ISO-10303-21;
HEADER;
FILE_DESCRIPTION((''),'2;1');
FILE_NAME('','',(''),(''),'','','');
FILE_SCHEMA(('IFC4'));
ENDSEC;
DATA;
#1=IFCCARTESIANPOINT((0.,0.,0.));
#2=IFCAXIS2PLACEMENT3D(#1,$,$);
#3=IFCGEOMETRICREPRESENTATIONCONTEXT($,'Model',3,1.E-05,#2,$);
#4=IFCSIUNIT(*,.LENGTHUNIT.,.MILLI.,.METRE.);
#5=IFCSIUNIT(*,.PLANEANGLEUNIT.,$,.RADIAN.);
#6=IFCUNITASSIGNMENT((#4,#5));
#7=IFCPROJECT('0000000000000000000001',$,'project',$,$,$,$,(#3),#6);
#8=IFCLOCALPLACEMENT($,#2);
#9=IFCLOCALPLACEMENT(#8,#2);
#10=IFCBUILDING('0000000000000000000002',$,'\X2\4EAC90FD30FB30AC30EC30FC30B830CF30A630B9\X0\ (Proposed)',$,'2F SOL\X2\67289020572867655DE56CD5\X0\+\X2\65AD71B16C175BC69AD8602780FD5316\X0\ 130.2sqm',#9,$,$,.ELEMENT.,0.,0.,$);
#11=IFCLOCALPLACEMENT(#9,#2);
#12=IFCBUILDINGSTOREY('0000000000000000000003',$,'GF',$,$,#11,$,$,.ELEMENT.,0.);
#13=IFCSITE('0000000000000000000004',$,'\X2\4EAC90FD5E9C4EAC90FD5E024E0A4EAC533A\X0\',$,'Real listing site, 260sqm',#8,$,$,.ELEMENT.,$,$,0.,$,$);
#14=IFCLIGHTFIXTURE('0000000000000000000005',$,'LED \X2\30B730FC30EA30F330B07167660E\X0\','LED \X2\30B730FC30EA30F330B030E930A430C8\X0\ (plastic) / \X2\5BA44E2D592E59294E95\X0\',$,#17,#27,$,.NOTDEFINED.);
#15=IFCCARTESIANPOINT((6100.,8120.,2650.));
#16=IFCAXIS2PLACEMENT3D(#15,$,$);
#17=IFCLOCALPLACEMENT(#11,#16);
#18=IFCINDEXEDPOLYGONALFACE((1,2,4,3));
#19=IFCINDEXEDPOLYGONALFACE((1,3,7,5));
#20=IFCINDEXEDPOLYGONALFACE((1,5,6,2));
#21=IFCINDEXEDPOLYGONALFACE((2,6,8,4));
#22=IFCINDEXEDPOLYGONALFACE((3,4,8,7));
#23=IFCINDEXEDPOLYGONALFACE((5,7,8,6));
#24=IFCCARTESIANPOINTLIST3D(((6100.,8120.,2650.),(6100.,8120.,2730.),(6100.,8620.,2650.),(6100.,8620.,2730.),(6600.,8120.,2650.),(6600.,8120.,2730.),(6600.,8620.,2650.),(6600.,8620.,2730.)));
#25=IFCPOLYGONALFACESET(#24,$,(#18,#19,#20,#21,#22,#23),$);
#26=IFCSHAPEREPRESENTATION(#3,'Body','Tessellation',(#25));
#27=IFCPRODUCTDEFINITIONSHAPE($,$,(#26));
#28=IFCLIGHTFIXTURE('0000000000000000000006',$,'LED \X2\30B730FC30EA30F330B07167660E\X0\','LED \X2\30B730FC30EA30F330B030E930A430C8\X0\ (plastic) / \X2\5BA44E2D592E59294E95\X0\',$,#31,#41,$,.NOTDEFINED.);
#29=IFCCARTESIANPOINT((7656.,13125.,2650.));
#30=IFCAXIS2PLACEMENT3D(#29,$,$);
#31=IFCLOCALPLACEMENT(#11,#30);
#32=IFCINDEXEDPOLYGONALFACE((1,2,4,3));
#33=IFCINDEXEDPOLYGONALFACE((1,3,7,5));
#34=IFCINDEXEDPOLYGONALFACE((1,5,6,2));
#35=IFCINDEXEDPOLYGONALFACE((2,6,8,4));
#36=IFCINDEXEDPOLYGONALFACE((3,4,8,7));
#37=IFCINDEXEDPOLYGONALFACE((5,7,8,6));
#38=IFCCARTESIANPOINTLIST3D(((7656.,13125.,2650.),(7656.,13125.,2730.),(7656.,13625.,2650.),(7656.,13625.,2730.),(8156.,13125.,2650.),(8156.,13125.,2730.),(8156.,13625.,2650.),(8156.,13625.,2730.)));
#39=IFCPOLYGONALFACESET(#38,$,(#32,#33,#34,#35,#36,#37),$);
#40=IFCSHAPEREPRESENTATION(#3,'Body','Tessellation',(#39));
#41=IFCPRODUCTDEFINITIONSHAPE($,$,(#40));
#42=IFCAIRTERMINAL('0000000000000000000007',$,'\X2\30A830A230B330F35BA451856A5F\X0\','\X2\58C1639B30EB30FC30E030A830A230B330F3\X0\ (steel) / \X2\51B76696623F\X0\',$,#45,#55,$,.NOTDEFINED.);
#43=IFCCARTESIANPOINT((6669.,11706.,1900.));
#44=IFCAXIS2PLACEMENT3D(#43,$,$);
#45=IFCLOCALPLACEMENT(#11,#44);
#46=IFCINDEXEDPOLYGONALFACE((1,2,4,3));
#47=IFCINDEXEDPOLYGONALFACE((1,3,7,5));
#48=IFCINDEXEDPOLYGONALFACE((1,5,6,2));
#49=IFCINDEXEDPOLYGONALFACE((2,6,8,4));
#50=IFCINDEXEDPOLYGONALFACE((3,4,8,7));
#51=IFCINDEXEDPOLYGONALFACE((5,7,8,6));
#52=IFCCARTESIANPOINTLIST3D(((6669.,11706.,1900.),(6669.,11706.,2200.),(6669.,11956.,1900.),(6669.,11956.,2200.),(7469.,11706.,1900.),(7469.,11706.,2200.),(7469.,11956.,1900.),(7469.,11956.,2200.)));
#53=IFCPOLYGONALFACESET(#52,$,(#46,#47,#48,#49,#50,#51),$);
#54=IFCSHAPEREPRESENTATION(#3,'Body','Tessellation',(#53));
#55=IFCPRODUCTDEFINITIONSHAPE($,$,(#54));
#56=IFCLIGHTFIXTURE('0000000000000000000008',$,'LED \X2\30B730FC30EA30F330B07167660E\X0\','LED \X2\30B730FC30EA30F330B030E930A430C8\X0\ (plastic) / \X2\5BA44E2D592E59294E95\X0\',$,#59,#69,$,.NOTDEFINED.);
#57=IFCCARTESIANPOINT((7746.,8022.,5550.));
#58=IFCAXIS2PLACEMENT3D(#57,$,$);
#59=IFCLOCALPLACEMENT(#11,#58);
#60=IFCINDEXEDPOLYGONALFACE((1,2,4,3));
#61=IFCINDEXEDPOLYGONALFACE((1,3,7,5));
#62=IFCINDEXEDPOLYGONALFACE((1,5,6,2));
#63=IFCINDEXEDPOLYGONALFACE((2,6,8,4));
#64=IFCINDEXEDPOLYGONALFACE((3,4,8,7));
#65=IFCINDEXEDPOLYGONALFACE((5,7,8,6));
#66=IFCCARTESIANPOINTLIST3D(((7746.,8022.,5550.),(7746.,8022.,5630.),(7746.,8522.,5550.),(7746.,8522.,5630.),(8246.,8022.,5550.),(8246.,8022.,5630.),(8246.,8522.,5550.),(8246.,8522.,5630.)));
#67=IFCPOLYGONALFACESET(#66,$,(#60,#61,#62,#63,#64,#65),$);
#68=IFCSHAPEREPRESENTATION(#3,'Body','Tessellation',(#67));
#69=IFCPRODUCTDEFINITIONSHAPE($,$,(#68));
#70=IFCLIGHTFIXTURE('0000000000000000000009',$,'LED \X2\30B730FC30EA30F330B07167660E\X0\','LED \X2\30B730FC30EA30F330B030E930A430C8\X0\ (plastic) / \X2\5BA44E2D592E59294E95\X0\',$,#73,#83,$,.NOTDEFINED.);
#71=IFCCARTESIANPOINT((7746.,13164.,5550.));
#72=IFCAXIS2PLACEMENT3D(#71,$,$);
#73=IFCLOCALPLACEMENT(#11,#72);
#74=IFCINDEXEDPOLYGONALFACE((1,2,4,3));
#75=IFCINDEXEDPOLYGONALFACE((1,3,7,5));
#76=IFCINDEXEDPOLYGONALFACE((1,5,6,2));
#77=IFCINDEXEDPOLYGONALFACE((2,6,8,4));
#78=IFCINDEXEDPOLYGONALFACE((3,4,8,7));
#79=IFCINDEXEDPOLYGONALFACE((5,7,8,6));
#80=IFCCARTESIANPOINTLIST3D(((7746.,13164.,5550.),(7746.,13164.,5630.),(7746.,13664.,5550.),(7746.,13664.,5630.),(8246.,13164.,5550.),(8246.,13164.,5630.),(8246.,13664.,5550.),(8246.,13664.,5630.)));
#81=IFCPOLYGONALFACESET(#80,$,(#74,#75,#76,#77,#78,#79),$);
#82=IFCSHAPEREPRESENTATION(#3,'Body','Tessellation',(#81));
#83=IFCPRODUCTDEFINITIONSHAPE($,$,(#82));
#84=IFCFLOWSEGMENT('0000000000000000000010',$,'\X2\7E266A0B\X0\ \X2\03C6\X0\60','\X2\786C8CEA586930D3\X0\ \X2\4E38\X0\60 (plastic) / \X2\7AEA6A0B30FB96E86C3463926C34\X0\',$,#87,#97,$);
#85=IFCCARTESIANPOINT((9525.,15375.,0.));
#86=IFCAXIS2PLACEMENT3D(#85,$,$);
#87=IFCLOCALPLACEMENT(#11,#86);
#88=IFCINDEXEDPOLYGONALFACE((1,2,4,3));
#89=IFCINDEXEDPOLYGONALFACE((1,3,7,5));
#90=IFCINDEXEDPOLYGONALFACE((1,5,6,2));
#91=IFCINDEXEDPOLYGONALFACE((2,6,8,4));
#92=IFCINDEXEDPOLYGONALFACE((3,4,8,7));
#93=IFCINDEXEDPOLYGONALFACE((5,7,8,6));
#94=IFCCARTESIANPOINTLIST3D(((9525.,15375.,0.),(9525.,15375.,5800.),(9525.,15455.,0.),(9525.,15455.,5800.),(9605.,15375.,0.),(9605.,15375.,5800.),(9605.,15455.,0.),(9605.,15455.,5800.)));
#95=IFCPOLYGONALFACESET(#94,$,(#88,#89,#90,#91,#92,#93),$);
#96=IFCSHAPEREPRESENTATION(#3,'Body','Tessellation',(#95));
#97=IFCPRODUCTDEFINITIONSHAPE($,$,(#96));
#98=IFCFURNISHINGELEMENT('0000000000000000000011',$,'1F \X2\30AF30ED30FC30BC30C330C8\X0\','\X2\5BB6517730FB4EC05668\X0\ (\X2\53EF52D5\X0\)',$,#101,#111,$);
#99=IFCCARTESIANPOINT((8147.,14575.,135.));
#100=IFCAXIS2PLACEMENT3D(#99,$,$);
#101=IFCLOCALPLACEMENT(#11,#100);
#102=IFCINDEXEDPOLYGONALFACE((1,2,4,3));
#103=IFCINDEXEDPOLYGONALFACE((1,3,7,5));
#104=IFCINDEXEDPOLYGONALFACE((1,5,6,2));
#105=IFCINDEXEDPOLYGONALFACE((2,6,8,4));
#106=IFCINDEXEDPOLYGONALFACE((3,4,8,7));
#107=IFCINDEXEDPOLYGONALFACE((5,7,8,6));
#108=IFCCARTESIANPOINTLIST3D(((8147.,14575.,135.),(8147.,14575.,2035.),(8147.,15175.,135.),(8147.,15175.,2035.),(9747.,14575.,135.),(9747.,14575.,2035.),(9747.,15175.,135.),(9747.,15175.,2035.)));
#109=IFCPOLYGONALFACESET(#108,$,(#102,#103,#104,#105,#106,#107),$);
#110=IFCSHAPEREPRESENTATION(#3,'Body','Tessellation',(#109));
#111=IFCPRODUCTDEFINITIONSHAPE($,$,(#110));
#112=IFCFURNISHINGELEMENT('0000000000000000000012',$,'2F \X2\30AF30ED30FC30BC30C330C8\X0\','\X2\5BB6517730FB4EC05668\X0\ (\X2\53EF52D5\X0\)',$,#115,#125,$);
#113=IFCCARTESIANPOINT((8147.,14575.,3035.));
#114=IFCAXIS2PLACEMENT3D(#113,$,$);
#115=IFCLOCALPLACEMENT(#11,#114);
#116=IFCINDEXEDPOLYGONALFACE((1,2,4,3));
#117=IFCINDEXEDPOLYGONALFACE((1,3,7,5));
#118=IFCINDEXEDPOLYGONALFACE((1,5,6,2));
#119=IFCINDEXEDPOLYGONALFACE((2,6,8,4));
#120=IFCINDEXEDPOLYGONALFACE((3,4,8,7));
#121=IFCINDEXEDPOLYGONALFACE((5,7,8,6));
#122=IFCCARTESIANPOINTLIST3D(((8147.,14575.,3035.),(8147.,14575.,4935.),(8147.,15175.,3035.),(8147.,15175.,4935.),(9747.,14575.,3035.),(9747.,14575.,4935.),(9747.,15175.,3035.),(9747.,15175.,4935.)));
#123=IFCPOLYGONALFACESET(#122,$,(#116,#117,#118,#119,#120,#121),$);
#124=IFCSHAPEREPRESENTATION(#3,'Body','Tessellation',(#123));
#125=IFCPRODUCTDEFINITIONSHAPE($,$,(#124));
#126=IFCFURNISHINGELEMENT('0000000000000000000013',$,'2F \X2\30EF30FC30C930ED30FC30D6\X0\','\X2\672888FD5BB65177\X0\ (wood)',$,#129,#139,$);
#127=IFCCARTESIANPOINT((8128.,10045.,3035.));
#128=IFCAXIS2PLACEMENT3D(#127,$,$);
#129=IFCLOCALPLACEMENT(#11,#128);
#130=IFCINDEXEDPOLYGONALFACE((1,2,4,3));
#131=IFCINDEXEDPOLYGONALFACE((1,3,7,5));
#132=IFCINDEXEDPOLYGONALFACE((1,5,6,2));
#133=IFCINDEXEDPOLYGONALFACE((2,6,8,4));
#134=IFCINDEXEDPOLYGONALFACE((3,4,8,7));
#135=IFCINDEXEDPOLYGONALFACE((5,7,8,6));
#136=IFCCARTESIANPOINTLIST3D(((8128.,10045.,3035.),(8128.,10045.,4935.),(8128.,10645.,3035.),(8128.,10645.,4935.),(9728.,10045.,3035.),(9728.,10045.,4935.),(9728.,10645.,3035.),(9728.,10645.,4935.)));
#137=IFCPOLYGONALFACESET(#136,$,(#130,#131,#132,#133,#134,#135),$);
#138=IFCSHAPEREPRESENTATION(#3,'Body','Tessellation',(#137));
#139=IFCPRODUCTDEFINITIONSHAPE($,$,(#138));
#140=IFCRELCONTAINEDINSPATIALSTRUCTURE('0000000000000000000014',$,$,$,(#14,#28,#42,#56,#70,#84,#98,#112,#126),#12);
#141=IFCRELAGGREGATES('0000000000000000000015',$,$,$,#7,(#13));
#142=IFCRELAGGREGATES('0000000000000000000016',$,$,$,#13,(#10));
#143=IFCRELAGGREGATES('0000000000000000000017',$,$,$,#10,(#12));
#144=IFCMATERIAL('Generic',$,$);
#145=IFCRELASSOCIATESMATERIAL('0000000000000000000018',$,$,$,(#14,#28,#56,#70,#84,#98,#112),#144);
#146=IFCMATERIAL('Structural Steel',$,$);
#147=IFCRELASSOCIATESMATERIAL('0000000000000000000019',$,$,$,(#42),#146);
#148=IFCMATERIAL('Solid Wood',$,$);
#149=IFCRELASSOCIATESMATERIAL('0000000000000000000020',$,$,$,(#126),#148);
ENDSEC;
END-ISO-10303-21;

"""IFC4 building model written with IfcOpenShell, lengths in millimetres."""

from ifc_helpers import new_model, si_unit, frame, frame_2d, origin, place, context, project, spatial, rectangle, extrude, material, element, save


model = new_model("IFC4")

# Units and contexts
model_context = context("Model", 3, precision=1e-05, world=origin())
ifc_project = project(units=[si_unit("LENGTHUNIT", "METRE", prefix="MILLI"), si_unit("PLANEANGLEUNIT", "RADIAN")], contexts=[model_context])

# Site, building, storey
site_placement = place(None, origin())
site = spatial("IfcSite", under=ifc_project, at=site_placement, Name="京都府京都市上京区", ObjectType="Real listing site, 260sqm", CompositionType="ELEMENT", RefElevation=0.0)
building_placement = place(site_placement, origin())
building = spatial("IfcBuilding", under=site, at=building_placement, Name="京都・ガレージハウス (Proposed)", ObjectType="2F SOL木造在来工法+断熱気密高性能化 130.2sqm", CompositionType="ELEMENT", ElevationOfRefHeight=0.0, ElevationOfTerrain=0.0)
storey_placement = place(building_placement, origin())
storey = spatial("IfcBuildingStorey", under=building, at=storey_placement, Name="GF", CompositionType="ELEMENT", Elevation=0.0)

# Shared definitions
ifc_material_1 = material(Name="Solid Wood")
ifc_material_2 = material(Name="Structural Steel")

# Shared definitions
ifc_material_3 = material(Name="Generic")

# Light fixtures
light_fixture_1_placement = place(storey_placement, frame((6100.0, 8120.0, 2650.0)))
element("IfcLightFixture", 1, at=light_fixture_1_placement, inside=storey, material=ifc_material_3, Name="LED シーリング照明", Description="LED シーリングライト (plastic) / 室中央天井", PredefinedType="NOTDEFINED", context=model_context, shape_type="SweptSolid", body=[
    extrude(rectangle(XDim=500.0, YDim=500.0, at=frame_2d((250.0, 250.0))), frame((6100.0, 8120.0, 2650.0)), (0.0, 0.0, 1.0), 80.0),
])
light_fixture_2_placement = place(storey_placement, frame((7656.0, 13125.0, 2650.0)))
element("IfcLightFixture", 2, at=light_fixture_2_placement, inside=storey, material=ifc_material_3, Name="LED シーリング照明", Description="LED シーリングライト (plastic) / 室中央天井", PredefinedType="NOTDEFINED", context=model_context, shape_type="SweptSolid", body=[
    extrude(rectangle(XDim=500.0, YDim=500.0, at=frame_2d((250.0, 250.0))), frame((7656.0, 13125.0, 2650.0)), (0.0, 0.0, 1.0), 80.0),
])

# Air terminal
air_terminal_placement = place(storey_placement, frame((6669.0, 11706.0, 1900.0)))
element("IfcAirTerminal", 3, at=air_terminal_placement, inside=storey, material=ifc_material_2, Name="エアコン室内機", Description="壁掛ルームエアコン (steel) / 冷暖房", PredefinedType="NOTDEFINED", context=model_context, shape_type="SweptSolid", body=[
    extrude(rectangle(XDim=800.0, YDim=250.0, at=frame_2d((400.0, 125.0))), frame((6669.0, 11706.0, 1900.0)), (0.0, 0.0, 1.0), 300.0),
])

# Light fixtures
light_fixture_3_placement = place(storey_placement, frame((7746.0, 8022.0, 5550.0)))
element("IfcLightFixture", 4, at=light_fixture_3_placement, inside=storey, material=ifc_material_3, Name="LED シーリング照明", Description="LED シーリングライト (plastic) / 室中央天井", PredefinedType="NOTDEFINED", context=model_context, shape_type="SweptSolid", body=[
    extrude(rectangle(XDim=500.0, YDim=500.0, at=frame_2d((250.0, 250.0))), frame((7746.0, 8022.0, 5550.0)), (0.0, 0.0, 1.0), 80.0),
])
light_fixture_4_placement = place(storey_placement, frame((7746.0, 13164.0, 5550.0)))
element("IfcLightFixture", 5, at=light_fixture_4_placement, inside=storey, material=ifc_material_3, Name="LED シーリング照明", Description="LED シーリングライト (plastic) / 室中央天井", PredefinedType="NOTDEFINED", context=model_context, shape_type="SweptSolid", body=[
    extrude(rectangle(XDim=500.0, YDim=500.0, at=frame_2d((250.0, 250.0))), frame((7746.0, 13164.0, 5550.0)), (0.0, 0.0, 1.0), 80.0),
])

# Flow segment
flow_segment_placement = place(storey_placement, frame((9525.0, 15375.0, 0.0)))
element("IfcFlowSegment", 6, at=flow_segment_placement, inside=storey, material=ifc_material_3, Name="縦樋 φ60", Description="硬質塩ビ 丸60 (plastic) / 竪樋・雨水排水", context=model_context, shape_type="SweptSolid", body=[
    extrude(rectangle(XDim=80.0, YDim=80.0, at=frame_2d((40.0, 40.0))), frame((9525.0, 15375.0, 0.0)), (0.0, 0.0, 1.0), 5800.0),
])

# Furnishing elements
furnishing_1_placement = place(storey_placement, frame((8147.0, 14575.0, 135.0)))
element("IfcFurnishingElement", 7, at=furnishing_1_placement, inside=storey, material=ifc_material_3, Name="1F クローゼット", Description="家具・什器 (可動)", context=model_context, shape_type="SweptSolid", body=[
    extrude(rectangle(XDim=1600.0, YDim=600.0, at=frame_2d((800.0, 300.0))), frame((8147.0, 14575.0, 135.0)), (0.0, 0.0, 1.0), 1900.0),
])
furnishing_2_placement = place(storey_placement, frame((8147.0, 14575.0, 3035.0)))
element("IfcFurnishingElement", 8, at=furnishing_2_placement, inside=storey, material=ifc_material_3, Name="2F クローゼット", Description="家具・什器 (可動)", context=model_context, shape_type="SweptSolid", body=[
    extrude(rectangle(XDim=1600.0, YDim=600.0, at=frame_2d((800.0, 300.0))), frame((8147.0, 14575.0, 3035.0)), (0.0, 0.0, 1.0), 1900.0),
])
furnishing_3_placement = place(storey_placement, frame((8128.0, 10045.0, 3035.0)))
element("IfcFurnishingElement", 9, at=furnishing_3_placement, inside=storey, material=ifc_material_1, Name="2F ワードローブ", Description="木製家具 (wood)", context=model_context, shape_type="SweptSolid", body=[
    extrude(rectangle(XDim=1600.0, YDim=600.0, at=frame_2d((800.0, 300.0))), frame((8128.0, 10045.0, 3035.0)), (0.0, 0.0, 1.0), 1900.0),
])

save(model, "model.ifc")
